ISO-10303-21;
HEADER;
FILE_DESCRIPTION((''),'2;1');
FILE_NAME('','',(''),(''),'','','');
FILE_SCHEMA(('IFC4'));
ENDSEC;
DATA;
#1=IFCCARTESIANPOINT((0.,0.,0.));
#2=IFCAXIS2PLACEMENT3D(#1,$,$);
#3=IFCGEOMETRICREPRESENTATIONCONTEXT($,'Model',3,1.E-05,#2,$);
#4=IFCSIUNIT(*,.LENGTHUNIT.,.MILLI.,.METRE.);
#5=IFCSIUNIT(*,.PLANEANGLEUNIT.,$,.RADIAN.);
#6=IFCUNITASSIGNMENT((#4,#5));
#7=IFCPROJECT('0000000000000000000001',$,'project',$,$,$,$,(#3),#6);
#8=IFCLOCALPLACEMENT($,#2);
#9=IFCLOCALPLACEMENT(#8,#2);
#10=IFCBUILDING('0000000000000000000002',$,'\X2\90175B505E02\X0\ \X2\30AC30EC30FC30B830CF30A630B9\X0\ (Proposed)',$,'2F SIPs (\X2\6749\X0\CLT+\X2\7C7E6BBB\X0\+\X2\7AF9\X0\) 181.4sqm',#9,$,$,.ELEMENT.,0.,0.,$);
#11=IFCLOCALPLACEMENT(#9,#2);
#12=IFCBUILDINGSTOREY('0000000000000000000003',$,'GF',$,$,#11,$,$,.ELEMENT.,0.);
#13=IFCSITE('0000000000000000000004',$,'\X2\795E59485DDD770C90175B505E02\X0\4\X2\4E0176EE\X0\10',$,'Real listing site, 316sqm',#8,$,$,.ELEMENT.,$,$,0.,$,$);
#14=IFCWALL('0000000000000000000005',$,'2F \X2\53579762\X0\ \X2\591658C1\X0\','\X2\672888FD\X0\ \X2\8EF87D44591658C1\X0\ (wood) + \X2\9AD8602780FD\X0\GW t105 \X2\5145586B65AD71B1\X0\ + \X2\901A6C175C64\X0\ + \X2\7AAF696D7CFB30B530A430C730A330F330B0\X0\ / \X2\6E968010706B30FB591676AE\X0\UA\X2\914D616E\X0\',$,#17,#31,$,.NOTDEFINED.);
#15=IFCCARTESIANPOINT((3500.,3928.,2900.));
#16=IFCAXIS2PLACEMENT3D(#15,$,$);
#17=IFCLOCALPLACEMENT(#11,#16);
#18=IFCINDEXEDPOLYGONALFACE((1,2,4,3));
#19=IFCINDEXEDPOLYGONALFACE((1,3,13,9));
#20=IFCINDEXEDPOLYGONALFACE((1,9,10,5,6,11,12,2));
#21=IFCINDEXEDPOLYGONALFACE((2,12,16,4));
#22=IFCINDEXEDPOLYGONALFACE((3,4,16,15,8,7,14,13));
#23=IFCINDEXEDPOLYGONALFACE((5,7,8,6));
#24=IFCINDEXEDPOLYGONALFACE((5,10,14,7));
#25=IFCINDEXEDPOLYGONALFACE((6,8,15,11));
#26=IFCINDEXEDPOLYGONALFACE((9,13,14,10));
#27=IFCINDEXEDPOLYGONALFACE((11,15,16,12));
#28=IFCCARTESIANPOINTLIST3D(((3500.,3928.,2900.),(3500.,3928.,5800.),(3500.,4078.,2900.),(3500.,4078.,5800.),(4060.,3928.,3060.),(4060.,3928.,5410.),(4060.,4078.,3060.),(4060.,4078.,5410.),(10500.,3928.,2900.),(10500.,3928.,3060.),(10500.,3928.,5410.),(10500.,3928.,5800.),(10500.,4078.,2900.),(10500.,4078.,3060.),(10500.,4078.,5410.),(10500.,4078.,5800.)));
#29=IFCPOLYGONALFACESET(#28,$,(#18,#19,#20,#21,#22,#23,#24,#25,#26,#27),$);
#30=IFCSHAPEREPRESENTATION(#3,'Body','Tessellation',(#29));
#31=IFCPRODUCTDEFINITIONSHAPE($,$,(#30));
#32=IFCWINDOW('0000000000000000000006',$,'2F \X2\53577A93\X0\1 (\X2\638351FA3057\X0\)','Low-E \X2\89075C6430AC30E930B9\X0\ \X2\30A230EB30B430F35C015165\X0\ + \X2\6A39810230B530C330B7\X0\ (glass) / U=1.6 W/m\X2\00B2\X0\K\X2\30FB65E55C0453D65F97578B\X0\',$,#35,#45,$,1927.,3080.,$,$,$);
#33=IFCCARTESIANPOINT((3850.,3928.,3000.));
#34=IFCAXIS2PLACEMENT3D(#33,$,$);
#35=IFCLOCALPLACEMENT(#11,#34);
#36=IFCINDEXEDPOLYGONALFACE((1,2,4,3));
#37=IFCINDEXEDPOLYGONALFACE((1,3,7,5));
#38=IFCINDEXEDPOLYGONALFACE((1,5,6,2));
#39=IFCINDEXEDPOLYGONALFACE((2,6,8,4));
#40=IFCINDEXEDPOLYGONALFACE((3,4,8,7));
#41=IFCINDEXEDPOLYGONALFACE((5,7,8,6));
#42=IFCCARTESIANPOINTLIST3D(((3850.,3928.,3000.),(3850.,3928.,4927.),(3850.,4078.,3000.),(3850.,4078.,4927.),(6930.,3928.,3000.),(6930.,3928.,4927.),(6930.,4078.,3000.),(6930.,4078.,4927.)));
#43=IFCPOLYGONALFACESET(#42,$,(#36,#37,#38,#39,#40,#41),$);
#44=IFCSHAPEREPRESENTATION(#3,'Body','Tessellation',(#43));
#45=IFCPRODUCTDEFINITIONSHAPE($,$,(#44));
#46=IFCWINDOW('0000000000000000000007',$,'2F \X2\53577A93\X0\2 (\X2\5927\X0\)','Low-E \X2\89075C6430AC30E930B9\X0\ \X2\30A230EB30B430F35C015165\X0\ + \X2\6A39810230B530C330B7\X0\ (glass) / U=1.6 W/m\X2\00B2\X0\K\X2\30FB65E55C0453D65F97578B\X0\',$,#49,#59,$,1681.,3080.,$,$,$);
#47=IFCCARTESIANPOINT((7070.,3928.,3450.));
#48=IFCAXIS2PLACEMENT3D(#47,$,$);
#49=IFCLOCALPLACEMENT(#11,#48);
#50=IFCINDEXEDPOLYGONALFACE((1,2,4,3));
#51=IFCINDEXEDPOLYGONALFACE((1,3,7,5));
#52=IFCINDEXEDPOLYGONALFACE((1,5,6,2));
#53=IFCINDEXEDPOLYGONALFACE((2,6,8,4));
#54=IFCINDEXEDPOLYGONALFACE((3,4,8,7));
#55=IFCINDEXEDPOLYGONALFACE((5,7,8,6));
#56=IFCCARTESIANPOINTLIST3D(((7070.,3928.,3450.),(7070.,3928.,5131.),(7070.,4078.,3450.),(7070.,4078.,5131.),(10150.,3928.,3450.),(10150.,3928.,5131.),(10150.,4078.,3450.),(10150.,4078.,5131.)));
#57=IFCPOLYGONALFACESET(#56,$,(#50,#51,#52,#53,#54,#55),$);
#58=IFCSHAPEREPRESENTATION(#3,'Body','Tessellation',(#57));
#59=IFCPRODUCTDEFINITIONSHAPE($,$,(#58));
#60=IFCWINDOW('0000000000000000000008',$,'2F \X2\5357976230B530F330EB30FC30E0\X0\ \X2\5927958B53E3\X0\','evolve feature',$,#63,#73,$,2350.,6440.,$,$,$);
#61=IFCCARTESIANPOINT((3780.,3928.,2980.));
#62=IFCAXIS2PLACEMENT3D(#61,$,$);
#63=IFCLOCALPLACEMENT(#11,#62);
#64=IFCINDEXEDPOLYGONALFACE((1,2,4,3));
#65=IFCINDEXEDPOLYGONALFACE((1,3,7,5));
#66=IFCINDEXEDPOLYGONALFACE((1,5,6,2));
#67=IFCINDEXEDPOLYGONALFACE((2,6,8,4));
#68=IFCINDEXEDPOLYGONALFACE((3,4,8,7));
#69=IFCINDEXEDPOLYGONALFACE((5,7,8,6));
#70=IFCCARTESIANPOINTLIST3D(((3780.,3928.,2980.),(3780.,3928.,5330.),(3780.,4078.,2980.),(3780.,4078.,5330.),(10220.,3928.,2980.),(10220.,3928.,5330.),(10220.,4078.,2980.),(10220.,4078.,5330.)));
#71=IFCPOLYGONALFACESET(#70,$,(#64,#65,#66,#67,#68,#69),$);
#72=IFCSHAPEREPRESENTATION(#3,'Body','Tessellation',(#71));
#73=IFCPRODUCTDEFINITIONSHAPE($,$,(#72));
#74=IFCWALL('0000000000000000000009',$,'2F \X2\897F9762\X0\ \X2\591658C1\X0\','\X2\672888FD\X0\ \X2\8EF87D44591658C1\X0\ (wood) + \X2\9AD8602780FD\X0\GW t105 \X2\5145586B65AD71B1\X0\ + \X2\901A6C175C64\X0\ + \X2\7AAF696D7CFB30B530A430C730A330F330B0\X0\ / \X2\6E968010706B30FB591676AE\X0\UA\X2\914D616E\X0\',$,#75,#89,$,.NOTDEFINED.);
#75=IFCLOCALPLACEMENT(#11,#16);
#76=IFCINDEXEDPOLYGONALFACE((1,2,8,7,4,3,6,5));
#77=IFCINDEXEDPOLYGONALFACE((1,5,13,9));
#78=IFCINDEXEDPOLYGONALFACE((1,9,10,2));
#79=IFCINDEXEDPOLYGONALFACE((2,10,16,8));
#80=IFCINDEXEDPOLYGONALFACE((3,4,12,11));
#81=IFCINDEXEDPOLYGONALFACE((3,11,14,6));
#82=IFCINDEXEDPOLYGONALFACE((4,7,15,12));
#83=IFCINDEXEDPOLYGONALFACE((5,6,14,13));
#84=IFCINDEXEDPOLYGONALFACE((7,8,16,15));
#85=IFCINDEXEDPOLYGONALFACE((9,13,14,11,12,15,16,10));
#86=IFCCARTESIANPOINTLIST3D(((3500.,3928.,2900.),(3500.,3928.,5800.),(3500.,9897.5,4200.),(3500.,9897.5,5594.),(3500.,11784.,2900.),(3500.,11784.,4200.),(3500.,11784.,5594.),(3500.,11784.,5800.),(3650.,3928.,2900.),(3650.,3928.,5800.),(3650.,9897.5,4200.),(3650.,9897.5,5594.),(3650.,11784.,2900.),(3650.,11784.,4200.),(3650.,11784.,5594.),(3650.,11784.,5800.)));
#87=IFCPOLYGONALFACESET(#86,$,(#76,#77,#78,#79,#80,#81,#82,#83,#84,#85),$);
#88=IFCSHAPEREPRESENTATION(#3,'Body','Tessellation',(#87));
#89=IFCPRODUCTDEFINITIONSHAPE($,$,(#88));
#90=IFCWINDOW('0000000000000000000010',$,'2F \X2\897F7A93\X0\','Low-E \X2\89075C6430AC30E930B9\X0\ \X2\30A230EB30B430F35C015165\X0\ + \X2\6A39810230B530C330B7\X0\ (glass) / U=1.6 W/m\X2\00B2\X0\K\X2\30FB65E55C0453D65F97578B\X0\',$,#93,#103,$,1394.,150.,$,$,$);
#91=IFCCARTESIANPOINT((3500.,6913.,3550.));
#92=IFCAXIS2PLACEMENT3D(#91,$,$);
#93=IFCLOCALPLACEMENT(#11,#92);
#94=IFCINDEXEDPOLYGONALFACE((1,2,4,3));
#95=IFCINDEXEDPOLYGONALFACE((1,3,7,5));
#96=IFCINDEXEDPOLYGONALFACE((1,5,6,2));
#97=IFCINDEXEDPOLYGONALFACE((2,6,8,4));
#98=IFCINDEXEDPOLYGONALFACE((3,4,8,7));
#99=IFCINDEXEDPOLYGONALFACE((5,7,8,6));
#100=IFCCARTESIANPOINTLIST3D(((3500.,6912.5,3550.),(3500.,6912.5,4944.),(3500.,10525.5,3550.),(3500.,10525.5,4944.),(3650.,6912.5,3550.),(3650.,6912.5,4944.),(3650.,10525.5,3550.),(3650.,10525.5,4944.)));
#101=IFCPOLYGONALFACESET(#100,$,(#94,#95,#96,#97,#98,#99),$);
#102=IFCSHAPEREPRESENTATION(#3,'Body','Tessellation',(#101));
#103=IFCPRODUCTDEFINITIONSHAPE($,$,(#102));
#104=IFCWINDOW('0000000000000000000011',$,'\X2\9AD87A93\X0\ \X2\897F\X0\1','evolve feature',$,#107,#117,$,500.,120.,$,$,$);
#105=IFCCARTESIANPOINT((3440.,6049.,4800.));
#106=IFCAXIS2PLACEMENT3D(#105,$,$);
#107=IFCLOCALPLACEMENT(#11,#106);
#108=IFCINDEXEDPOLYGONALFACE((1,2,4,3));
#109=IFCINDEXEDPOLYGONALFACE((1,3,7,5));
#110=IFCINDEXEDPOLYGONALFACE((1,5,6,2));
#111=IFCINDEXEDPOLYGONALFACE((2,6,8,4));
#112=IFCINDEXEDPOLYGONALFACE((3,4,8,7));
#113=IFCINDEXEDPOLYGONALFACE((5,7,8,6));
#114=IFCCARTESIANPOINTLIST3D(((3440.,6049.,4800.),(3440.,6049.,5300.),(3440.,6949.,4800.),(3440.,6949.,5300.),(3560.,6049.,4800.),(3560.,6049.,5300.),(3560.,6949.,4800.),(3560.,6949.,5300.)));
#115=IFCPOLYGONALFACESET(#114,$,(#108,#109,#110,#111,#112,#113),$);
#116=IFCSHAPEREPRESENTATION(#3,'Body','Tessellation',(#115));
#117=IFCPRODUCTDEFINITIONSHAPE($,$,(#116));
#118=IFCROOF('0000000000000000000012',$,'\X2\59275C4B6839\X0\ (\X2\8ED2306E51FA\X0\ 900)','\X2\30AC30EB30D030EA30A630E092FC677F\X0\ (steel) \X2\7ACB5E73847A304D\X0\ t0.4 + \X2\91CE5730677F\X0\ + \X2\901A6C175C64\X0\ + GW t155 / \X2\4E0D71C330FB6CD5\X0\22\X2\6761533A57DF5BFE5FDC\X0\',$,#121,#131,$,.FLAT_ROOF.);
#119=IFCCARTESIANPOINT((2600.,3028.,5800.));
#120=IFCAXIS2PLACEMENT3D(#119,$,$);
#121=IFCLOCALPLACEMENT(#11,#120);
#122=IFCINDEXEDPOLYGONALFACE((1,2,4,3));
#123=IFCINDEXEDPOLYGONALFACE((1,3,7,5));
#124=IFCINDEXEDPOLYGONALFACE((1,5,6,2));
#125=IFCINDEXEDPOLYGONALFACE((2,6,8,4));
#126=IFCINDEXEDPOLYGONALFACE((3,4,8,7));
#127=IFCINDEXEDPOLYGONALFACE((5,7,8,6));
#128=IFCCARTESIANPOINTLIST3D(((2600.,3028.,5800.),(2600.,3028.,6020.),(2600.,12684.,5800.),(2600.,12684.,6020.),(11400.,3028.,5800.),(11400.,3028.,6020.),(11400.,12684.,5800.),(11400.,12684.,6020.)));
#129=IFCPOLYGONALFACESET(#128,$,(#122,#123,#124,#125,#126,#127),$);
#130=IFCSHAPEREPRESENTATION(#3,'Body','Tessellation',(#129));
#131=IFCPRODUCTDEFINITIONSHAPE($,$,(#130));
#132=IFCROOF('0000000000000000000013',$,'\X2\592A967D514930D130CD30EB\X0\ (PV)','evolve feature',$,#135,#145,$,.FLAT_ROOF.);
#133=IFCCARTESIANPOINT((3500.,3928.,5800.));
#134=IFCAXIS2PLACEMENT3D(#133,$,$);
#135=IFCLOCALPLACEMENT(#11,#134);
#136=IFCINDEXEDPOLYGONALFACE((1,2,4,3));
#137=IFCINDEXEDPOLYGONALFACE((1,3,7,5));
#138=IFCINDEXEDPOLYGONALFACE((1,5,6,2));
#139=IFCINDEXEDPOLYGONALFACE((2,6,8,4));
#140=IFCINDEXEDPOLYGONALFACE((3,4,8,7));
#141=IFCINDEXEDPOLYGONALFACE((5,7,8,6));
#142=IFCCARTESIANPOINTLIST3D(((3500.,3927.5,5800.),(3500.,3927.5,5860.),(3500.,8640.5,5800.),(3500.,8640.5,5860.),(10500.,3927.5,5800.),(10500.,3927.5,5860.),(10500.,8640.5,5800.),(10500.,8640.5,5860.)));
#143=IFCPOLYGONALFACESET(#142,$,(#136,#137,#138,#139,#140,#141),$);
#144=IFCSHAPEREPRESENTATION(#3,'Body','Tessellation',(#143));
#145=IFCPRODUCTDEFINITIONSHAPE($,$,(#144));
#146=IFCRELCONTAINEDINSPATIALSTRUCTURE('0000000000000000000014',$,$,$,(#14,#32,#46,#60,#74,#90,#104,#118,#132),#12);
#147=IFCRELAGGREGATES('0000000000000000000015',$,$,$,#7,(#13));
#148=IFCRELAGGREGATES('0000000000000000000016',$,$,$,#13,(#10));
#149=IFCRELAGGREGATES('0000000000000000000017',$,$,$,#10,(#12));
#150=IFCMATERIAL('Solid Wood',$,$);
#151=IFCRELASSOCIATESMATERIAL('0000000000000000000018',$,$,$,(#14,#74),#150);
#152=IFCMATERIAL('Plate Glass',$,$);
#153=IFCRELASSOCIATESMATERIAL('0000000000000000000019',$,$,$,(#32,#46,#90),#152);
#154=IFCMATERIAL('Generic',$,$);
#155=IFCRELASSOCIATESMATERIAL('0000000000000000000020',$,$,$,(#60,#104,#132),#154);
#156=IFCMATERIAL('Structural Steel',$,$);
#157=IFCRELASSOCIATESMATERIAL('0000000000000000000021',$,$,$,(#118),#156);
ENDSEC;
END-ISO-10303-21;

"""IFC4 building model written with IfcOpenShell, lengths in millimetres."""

from ifc_helpers import new_model, si_unit, frame, frame_2d, origin, place, context, project, spatial, rectangle, extrude, material, element, fill, save


model = new_model("IFC4")

# Units and contexts
model_context = context("Model", 3, precision=1e-05, world=origin())
ifc_project = project(units=[si_unit("LENGTHUNIT", "METRE", prefix="MILLI"), si_unit("PLANEANGLEUNIT", "RADIAN")], contexts=[model_context])

# Site, building, storey
site_placement = place(None, origin())
site = spatial("IfcSite", under=ifc_project, at=site_placement, Name="神奈川県逗子市4丁目10", ObjectType="Real listing site, 316sqm", CompositionType="ELEMENT", RefElevation=0.0)
building_placement = place(site_placement, origin())
building = spatial("IfcBuilding", under=site, at=building_placement, Name="逗子市 ガレージハウス (Proposed)", ObjectType="2F SIPs (杉CLT+籾殻+竹) 181.4sqm", CompositionType="ELEMENT", ElevationOfRefHeight=0.0, ElevationOfTerrain=0.0)
storey_placement = place(building_placement, origin())
storey = spatial("IfcBuildingStorey", under=building, at=storey_placement, Name="GF", CompositionType="ELEMENT", Elevation=0.0)

# Shared definitions
ifc_material_1 = material(Name="Solid Wood")
ifc_material_2 = material(Name="Generic")

# Shared definitions
ifc_material_3 = material(Name="Plate Glass")

# Walls, openings, windows
wall_1_placement = place(storey_placement, frame((3500.0, 3928.0, 2900.0)))
wall_1 = element("IfcWall", 1, at=wall_1_placement, inside=storey, material=ifc_material_1, Name="2F 南面 外壁", Description="木製 軸組外壁 (wood) + 高性能GW t105 充填断熱 + 通気層 + 窯業系サイディング / 準耐火・外皮UA配慮", PredefinedType="NOTDEFINED", context=model_context, shape_type="SweptSolid", body=[
    extrude(rectangle(XDim=7000.0, YDim=150.0, at=frame_2d((3500.0, 75.0))), frame((3500.0, 3928.0, 2900.0)), (0.0, 0.0, 1.0), 2900.0),
])
opening_1_placement = place(storey_placement, frame((3850.0, 3928.0, 3000.0)))
opening_1 = element("IfcOpeningElement", 2, at=opening_1_placement, cuts=wall_1, PredefinedType="NOTDEFINED", context=model_context, shape_type="SweptSolid", body=[
    extrude(rectangle(XDim=3080.0, YDim=150.0, at=frame_2d((1540.0, 75.0))), frame((3850.0, 3928.0, 3000.0)), (0.0, 0.0, 1.0), 1927.0),
])
opening_2_placement = place(storey_placement, frame((7070.0, 3928.0, 3450.0)))
opening_2 = element("IfcOpeningElement", 3, at=opening_2_placement, cuts=wall_1, PredefinedType="NOTDEFINED", context=model_context, shape_type="SweptSolid", body=[
    extrude(rectangle(XDim=3080.0, YDim=150.0, at=frame_2d((1540.0, 75.0))), frame((7070.0, 3928.0, 3450.0)), (0.0, 0.0, 1.0), 1681.0),
])
opening_3_placement = place(storey_placement, frame((3780.0, 3928.0, 2980.0)))
opening_3 = element("IfcOpeningElement", 4, at=opening_3_placement, cuts=wall_1, PredefinedType="NOTDEFINED", context=model_context, shape_type="SweptSolid", body=[
    extrude(rectangle(XDim=6440.0, YDim=150.0, at=frame_2d((3220.0, 75.0))), frame((3780.0, 3928.0, 2980.0)), (0.0, 0.0, 1.0), 2350.0),
])
window_1_placement = place(storey_placement, frame((3850.0, 3928.0, 3000.0)))
window_1 = element("IfcWindow", 5, at=window_1_placement, inside=storey, material=ifc_material_3, Name="2F 南窓1 (掃出し)", Description="Low-E 複層ガラス アルゴン封入 + 樹脂サッシ (glass) / U=1.6 W/m²K・日射取得型", OverallHeight=1927.0, OverallWidth=3080.0, context=model_context, shape_type="SweptSolid", body=[
    extrude(rectangle(XDim=3080.0, YDim=150.0, at=frame_2d((1540.0, 75.0))), frame((3850.0, 3928.0, 3000.0)), (0.0, 0.0, 1.0), 1927.0),
])
fill(opening_1, window_1)
window_2_placement = place(storey_placement, frame((7070.0, 3928.0, 3450.0)))
window_2 = element("IfcWindow", 6, at=window_2_placement, inside=storey, material=ifc_material_3, Name="2F 南窓2 (大)", Description="Low-E 複層ガラス アルゴン封入 + 樹脂サッシ (glass) / U=1.6 W/m²K・日射取得型", OverallHeight=1681.0, OverallWidth=3080.0, context=model_context, shape_type="SweptSolid", body=[
    extrude(rectangle(XDim=3080.0, YDim=150.0, at=frame_2d((1540.0, 75.0))), frame((7070.0, 3928.0, 3450.0)), (0.0, 0.0, 1.0), 1681.0),
])
fill(opening_2, window_2)
window_3_placement = place(storey_placement, frame((3780.0, 3928.0, 2980.0)))
window_3 = element("IfcWindow", 7, at=window_3_placement, inside=storey, material=ifc_material_2, Name="2F 南面サンルーム 大開口", Description="evolve feature", OverallHeight=2350.0, OverallWidth=6440.0, context=model_context, shape_type="SweptSolid", body=[
    extrude(rectangle(XDim=6440.0, YDim=150.0, at=frame_2d((3220.0, 75.0))), frame((3780.0, 3928.0, 2980.0)), (0.0, 0.0, 1.0), 2350.0),
])
fill(opening_3, window_3)
wall_2_placement = place(storey_placement, frame((3500.0, 3928.0, 2900.0)))
wall_2 = element("IfcWall", 8, at=wall_2_placement, inside=storey, material=ifc_material_1, Name="2F 西面 外壁", Description="木製 軸組外壁 (wood) + 高性能GW t105 充填断熱 + 通気層 + 窯業系サイディング / 準耐火・外皮UA配慮", PredefinedType="NOTDEFINED", context=model_context, shape_type="SweptSolid", body=[
    extrude(rectangle(XDim=150.0, YDim=7856.0, at=frame_2d((75.0, 3928.0))), frame((3500.0, 3928.0, 2900.0)), (0.0, 0.0, 1.0), 2900.0),
])
opening_4_placement = place(storey_placement, frame((3500.0, 6913.0, 3550.0)))
opening_4 = element("IfcOpeningElement", 9, at=opening_4_placement, cuts=wall_2, PredefinedType="NOTDEFINED", context=model_context, shape_type="SweptSolid", body=[
    extrude(rectangle(XDim=150.0, YDim=3613.0, at=frame_2d((75.0, 1806.0))), frame((3500.0, 6913.0, 3550.0)), (0.0, 0.0, 1.0), 1394.0),
])
opening_5_placement = place(storey_placement, frame((3440.0, 6049.0, 4800.0)))
opening_5 = element("IfcOpeningElement", 10, at=opening_5_placement, cuts=wall_2, PredefinedType="NOTDEFINED", context=model_context, shape_type="SweptSolid", body=[
    extrude(rectangle(XDim=120.0, YDim=900.0, at=frame_2d((60.0, 450.0))), frame((3440.0, 6049.0, 4800.0)), (0.0, 0.0, 1.0), 500.0),
])
window_4_placement = place(storey_placement, frame((3500.0, 6913.0, 3550.0)))
window_4 = element("IfcWindow", 11, at=window_4_placement, inside=storey, material=ifc_material_3, Name="2F 西窓", Description="Low-E 複層ガラス アルゴン封入 + 樹脂サッシ (glass) / U=1.6 W/m²K・日射取得型", OverallHeight=1394.0, OverallWidth=150.0, context=model_context, shape_type="SweptSolid", body=[
    extrude(rectangle(XDim=150.0, YDim=3613.0, at=frame_2d((75.0, 1806.0))), frame((3500.0, 6913.0, 3550.0)), (0.0, 0.0, 1.0), 1394.0),
])
fill(opening_4, window_4)
window_5_placement = place(storey_placement, frame((3440.0, 6049.0, 4800.0)))
window_5 = element("IfcWindow", 12, at=window_5_placement, inside=storey, material=ifc_material_2, Name="高窓 西1", Description="evolve feature", OverallHeight=500.0, OverallWidth=120.0, context=model_context, shape_type="SweptSolid", body=[
    extrude(rectangle(XDim=120.0, YDim=900.0, at=frame_2d((60.0, 450.0))), frame((3440.0, 6049.0, 4800.0)), (0.0, 0.0, 1.0), 500.0),
])
fill(opening_5, window_5)

# Roofs
ifc_material_4 = material(Name="Structural Steel")
roof_1_placement = place(storey_placement, frame((2600.0, 3028.0, 5800.0)))
element("IfcRoof", 13, at=roof_1_placement, inside=storey, material=ifc_material_4, Name="大屋根 (軒の出 900)", Description="ガルバリウム鋼板 (steel) 立平葺き t0.4 + 野地板 + 通気層 + GW t155 / 不燃・法22条区域対応", PredefinedType="FLAT_ROOF", context=model_context, shape_type="SweptSolid", body=[
    extrude(rectangle(XDim=8800.0, YDim=9656.0, at=frame_2d((4400.0, 4828.0))), frame((2600.0, 3028.0, 5800.0)), (0.0, 0.0, 1.0), 220.0),
])
roof_2_placement = place(storey_placement, frame((3500.0, 3928.0, 5800.0)))
element("IfcRoof", 14, at=roof_2_placement, inside=storey, material=ifc_material_2, Name="太陽光パネル (PV)", Description="evolve feature", PredefinedType="FLAT_ROOF", context=model_context, shape_type="SweptSolid", body=[
    extrude(rectangle(XDim=7000.0, YDim=4713.0, at=frame_2d((3500.0, 2356.0))), frame((3500.0, 3928.0, 5800.0)), (0.0, 0.0, 1.0), 60.0),
])

save(model, "model.ifc")
